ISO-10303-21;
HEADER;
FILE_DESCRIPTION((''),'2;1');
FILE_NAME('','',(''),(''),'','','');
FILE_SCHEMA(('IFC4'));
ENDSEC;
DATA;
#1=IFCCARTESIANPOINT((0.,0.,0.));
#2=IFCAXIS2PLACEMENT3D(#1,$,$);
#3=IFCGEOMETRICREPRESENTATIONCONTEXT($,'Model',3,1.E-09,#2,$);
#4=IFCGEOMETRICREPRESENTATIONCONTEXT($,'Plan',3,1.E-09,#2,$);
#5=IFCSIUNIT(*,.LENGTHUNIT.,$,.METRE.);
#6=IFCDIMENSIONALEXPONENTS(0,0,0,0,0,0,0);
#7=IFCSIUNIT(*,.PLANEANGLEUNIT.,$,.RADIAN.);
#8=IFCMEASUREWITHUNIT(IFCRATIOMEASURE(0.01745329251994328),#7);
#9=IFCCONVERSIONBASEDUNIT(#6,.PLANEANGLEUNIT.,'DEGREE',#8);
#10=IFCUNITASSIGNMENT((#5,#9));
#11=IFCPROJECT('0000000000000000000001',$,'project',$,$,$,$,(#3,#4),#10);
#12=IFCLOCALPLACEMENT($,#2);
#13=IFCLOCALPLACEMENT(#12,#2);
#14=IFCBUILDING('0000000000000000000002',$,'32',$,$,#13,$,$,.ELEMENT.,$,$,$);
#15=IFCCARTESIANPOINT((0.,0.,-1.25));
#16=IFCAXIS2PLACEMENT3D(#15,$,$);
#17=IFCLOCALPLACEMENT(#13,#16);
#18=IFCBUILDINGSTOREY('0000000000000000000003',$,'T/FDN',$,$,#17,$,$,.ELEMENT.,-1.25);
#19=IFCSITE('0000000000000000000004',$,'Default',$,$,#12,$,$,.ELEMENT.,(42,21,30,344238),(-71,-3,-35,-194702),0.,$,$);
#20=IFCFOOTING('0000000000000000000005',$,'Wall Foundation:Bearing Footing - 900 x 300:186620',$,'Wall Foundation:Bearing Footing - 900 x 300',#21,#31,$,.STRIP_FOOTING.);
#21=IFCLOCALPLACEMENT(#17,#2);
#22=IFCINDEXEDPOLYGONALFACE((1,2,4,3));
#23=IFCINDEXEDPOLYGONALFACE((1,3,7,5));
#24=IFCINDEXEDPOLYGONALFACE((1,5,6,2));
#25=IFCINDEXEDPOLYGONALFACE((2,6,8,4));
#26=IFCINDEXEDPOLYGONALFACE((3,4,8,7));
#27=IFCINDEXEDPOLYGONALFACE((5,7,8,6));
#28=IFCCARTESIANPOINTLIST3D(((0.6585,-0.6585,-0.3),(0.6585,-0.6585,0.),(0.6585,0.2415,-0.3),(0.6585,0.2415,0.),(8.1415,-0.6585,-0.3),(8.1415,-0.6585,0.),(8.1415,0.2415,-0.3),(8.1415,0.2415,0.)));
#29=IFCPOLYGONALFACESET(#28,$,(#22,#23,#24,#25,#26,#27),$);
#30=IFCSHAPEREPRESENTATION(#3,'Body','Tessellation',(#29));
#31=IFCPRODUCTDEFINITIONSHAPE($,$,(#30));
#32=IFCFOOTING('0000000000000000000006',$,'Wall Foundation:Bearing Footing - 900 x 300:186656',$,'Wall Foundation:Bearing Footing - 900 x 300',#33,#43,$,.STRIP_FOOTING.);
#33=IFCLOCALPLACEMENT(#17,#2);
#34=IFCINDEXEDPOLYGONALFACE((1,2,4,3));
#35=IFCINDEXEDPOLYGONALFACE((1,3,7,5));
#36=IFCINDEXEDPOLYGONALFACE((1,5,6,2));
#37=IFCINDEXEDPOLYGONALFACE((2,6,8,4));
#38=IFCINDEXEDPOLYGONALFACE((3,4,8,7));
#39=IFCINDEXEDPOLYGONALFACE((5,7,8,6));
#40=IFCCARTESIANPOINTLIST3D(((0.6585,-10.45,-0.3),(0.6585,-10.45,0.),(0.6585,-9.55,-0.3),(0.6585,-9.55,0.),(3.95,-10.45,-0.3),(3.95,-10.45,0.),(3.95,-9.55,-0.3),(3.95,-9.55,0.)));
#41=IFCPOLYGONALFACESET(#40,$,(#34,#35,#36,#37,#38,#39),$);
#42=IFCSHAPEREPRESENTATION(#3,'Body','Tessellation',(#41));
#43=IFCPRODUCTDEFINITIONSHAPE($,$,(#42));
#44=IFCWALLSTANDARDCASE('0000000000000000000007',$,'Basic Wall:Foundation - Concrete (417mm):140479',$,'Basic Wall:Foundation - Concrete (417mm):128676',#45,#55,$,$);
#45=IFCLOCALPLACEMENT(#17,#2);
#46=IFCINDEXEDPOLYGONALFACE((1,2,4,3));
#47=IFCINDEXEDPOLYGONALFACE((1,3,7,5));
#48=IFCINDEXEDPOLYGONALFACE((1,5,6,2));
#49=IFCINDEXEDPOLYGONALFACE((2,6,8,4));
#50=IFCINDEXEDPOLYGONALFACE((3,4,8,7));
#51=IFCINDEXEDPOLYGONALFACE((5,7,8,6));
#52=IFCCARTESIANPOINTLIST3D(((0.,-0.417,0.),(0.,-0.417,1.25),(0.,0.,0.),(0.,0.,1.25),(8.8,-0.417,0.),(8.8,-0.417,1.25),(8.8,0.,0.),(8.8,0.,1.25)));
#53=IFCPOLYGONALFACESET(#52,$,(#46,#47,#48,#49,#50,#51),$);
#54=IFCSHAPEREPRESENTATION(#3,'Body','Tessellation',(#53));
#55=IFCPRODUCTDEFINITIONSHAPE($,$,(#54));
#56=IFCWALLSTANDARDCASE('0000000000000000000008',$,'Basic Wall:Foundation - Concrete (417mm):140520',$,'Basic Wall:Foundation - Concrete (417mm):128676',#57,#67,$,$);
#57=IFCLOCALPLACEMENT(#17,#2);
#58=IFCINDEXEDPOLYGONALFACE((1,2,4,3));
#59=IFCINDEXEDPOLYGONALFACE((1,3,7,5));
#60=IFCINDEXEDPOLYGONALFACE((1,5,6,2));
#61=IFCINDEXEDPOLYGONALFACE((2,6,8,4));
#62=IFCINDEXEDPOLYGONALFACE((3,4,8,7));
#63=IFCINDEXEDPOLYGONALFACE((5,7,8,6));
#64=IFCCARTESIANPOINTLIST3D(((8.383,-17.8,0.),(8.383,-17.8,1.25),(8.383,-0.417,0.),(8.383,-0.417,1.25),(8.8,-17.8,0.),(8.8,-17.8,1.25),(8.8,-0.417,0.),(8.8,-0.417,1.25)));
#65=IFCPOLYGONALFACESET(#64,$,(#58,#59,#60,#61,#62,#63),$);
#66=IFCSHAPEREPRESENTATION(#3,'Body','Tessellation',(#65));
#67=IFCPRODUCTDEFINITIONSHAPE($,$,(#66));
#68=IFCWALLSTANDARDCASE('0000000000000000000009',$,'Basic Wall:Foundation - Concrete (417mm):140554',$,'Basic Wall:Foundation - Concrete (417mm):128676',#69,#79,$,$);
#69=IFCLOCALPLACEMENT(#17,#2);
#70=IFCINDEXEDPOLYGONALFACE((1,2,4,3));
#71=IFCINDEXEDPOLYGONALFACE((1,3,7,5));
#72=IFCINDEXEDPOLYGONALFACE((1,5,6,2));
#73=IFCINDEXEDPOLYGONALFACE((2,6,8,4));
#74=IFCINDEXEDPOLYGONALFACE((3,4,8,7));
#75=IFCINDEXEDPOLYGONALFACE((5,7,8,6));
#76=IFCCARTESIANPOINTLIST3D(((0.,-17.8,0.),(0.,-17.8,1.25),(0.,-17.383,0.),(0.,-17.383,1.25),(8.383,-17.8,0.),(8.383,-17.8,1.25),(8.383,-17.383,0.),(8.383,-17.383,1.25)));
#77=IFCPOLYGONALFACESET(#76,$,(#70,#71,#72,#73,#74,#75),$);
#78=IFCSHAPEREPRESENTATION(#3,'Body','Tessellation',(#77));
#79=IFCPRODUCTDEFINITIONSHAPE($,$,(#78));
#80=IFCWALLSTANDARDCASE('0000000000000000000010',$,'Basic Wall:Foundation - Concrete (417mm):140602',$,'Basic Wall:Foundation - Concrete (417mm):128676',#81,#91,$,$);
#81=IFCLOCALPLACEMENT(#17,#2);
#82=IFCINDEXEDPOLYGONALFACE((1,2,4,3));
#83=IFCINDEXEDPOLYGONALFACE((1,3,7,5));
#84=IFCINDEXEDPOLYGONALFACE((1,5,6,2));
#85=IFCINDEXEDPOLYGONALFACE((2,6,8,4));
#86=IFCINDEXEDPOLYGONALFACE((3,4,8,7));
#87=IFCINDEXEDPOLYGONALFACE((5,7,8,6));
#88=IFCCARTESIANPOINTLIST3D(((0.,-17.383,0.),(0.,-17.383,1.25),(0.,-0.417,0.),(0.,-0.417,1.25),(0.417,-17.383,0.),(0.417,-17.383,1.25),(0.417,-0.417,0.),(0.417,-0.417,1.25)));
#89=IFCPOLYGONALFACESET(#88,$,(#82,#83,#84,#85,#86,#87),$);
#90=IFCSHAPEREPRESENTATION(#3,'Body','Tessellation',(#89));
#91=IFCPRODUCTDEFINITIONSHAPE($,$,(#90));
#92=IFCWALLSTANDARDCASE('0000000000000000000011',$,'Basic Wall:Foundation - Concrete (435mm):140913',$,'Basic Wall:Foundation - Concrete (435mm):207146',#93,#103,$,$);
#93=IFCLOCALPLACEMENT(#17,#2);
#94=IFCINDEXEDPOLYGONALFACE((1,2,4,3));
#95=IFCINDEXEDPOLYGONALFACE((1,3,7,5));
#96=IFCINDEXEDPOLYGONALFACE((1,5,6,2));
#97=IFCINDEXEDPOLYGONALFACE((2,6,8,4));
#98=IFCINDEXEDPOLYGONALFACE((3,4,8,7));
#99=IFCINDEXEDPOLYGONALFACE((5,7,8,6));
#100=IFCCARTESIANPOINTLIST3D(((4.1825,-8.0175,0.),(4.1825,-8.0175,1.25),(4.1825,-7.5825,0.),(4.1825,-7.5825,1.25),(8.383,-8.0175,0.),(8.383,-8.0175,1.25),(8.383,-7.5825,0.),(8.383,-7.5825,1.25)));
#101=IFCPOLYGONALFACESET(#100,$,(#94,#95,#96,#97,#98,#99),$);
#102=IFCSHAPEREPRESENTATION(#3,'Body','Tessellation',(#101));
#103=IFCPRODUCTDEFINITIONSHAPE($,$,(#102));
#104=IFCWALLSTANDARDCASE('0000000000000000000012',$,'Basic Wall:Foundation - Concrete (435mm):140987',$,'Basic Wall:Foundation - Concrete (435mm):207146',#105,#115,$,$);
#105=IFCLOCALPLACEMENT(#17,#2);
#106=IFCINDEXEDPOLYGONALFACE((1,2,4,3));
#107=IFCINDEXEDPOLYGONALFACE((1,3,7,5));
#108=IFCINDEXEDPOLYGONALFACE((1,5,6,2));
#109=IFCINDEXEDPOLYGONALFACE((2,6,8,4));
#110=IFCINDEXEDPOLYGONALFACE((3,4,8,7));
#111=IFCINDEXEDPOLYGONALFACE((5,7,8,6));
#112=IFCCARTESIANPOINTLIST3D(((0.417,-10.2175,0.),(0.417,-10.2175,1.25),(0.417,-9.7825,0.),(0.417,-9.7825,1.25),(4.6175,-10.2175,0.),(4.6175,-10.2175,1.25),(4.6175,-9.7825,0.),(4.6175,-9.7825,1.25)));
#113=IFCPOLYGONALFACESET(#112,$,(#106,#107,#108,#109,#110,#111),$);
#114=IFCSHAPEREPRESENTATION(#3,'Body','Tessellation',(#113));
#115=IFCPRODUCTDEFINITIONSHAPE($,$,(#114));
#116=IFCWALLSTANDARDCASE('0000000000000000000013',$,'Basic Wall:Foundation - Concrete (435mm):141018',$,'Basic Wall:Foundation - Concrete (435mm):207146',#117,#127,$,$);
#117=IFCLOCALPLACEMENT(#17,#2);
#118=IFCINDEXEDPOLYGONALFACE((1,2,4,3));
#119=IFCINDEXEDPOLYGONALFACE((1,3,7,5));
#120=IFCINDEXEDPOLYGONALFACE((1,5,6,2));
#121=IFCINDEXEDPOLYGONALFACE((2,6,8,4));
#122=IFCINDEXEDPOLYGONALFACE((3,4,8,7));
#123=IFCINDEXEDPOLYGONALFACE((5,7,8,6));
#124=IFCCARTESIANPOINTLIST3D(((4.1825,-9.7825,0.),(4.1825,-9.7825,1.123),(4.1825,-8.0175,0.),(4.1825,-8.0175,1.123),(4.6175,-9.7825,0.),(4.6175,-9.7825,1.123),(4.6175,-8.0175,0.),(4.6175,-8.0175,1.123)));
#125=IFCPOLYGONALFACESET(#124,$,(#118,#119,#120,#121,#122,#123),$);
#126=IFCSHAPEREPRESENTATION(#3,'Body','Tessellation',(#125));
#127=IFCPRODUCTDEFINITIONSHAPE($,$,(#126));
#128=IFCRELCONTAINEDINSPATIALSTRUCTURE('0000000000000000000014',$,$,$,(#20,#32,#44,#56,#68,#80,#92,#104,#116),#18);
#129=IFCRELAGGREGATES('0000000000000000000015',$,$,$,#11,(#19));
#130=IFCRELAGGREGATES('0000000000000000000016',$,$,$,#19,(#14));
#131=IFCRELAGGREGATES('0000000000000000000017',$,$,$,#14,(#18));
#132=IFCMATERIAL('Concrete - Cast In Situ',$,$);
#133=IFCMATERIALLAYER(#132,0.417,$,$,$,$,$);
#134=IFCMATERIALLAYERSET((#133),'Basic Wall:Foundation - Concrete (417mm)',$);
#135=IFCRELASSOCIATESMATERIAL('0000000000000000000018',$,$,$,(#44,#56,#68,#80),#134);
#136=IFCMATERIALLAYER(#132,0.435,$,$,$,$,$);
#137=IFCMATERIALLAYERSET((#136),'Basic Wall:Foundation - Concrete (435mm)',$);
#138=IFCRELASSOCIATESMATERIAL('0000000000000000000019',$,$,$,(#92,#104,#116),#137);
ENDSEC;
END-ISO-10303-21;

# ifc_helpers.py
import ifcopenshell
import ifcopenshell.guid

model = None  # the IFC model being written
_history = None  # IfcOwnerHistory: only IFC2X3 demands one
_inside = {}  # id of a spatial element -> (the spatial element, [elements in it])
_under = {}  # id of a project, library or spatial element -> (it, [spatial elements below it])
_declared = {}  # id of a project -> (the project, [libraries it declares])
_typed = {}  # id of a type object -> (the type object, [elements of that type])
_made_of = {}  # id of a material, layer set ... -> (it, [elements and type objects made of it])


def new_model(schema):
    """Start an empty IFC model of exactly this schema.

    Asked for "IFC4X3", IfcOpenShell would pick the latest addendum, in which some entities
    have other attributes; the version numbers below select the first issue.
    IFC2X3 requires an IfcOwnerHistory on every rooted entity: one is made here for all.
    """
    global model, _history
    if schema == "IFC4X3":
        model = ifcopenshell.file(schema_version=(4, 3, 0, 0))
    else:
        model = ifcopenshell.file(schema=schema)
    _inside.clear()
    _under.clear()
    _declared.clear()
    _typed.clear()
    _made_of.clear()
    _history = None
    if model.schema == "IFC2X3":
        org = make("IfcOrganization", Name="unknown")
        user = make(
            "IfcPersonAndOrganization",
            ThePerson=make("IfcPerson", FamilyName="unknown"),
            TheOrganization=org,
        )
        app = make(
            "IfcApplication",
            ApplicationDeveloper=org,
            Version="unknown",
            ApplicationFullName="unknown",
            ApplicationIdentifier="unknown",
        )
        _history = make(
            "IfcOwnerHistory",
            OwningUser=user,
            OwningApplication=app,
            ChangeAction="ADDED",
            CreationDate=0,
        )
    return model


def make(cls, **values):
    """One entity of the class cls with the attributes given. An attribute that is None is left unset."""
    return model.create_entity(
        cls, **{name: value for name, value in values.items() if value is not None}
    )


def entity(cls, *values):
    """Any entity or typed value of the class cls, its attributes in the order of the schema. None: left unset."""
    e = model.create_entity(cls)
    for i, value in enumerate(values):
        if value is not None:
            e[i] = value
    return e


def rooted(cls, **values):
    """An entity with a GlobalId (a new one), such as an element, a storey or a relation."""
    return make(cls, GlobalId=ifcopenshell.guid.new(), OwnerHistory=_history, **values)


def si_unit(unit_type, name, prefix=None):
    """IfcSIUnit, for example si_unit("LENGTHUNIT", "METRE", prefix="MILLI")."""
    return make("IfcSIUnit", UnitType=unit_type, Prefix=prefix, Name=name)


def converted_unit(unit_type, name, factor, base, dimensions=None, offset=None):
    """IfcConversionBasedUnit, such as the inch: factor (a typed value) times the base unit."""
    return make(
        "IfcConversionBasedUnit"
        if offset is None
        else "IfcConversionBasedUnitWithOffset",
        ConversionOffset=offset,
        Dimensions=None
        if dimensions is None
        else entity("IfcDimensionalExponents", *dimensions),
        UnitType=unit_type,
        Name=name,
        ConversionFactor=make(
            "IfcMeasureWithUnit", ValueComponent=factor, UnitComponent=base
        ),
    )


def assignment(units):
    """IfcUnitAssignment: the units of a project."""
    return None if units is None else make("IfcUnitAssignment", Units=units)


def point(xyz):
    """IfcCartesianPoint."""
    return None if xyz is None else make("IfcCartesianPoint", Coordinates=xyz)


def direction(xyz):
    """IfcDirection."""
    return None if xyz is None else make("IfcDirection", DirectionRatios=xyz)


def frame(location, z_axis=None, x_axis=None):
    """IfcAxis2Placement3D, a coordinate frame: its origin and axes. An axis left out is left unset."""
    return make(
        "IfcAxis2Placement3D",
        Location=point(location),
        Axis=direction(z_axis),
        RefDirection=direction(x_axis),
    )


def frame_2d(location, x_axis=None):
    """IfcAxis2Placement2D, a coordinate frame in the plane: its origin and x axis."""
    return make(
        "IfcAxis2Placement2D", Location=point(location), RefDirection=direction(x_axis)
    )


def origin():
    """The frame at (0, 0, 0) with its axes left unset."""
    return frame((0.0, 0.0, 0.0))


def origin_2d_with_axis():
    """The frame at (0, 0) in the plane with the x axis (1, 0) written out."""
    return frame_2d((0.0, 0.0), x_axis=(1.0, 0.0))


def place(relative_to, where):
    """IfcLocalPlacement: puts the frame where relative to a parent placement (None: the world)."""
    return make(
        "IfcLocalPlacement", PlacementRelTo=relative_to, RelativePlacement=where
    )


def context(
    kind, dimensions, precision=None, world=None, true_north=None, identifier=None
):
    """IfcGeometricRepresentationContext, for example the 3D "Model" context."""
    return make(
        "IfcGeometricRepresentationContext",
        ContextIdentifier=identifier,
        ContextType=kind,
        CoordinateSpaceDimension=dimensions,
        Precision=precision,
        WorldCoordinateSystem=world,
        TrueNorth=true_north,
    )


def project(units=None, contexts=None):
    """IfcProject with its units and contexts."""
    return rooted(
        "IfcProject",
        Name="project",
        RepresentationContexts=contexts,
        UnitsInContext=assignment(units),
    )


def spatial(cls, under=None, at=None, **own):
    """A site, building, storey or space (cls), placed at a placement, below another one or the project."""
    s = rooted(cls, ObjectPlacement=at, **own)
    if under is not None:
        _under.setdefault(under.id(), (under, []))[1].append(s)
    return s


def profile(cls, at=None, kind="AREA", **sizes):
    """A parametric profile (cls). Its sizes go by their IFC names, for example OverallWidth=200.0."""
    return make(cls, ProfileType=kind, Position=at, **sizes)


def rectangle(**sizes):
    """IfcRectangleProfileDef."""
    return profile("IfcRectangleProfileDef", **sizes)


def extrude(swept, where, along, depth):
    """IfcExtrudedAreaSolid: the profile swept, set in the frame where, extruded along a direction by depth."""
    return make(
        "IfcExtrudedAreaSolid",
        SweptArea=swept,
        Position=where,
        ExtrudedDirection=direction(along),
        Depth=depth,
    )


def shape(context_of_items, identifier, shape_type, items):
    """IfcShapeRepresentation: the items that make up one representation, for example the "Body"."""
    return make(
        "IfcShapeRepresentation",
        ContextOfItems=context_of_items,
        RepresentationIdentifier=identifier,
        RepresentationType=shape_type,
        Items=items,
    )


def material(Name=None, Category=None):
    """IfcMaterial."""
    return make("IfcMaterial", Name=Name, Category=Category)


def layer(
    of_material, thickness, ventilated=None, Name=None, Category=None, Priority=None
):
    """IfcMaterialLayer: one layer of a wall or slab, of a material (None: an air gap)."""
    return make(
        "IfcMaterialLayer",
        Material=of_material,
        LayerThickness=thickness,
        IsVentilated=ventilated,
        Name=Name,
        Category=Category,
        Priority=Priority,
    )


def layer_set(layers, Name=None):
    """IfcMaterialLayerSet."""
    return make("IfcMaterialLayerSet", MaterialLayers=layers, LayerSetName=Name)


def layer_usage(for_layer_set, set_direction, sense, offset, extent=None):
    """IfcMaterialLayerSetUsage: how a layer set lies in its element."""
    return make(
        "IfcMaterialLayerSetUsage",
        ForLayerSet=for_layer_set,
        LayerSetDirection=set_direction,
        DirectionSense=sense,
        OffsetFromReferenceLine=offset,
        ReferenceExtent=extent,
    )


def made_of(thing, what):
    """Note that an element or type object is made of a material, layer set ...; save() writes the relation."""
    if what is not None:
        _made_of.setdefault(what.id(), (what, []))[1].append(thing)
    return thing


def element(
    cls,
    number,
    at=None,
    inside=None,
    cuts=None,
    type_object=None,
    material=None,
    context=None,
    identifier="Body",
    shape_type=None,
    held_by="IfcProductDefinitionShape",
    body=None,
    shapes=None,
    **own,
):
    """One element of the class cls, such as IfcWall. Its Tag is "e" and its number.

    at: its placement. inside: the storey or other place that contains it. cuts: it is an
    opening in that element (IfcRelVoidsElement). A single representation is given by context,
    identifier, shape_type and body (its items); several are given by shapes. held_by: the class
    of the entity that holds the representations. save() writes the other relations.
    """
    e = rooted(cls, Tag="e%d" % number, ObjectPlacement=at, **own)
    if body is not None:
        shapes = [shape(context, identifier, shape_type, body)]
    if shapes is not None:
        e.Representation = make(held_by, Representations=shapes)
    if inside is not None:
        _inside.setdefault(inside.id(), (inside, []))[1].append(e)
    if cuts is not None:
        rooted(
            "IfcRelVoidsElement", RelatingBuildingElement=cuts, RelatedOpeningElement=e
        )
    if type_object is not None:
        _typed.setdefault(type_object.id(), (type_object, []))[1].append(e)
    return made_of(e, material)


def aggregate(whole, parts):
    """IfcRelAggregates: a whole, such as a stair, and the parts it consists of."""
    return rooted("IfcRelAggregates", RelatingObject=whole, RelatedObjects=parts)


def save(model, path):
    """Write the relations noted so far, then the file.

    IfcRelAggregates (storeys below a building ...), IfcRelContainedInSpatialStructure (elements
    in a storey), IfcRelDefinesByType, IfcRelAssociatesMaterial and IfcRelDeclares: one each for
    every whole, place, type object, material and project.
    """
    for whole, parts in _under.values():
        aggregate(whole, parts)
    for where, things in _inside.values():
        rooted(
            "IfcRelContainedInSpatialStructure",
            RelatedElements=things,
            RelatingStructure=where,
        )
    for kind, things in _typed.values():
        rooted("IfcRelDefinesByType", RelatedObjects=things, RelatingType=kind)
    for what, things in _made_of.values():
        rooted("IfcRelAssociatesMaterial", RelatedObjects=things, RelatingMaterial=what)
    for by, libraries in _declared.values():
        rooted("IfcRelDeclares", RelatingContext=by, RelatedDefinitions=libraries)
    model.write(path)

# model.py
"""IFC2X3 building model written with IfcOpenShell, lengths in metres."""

from ifc_helpers import new_model, entity, si_unit, converted_unit, frame, frame_2d, origin, origin_2d_with_axis, place, context, project, spatial, rectangle, extrude, material, layer, layer_set, layer_usage, element, save


model = new_model("IFC2X3")

# Units and contexts
model_context = context("Model", 3, precision=1e-09, world=origin())
plan_context = context("Plan", 3, precision=1e-09, world=origin())
ifc_project = project(units=[si_unit("LENGTHUNIT", "METRE"), converted_unit("PLANEANGLEUNIT", "DEGREE", entity("IfcRatioMeasure", 0.01745329251994328), si_unit("PLANEANGLEUNIT", "RADIAN"), dimensions=[0, 0, 0, 0, 0, 0, 0])], contexts=[model_context, plan_context])

# Site, building, storey
site_placement = place(None, origin())
site = spatial("IfcSite", under=ifc_project, at=site_placement, Name="Default", CompositionType="ELEMENT", RefLatitude=(42, 21, 30, 344238), RefLongitude=(-71, -3, -35, -194702), RefElevation=0.0)
building_placement = place(site_placement, origin())
building = spatial("IfcBuilding", under=site, at=building_placement, Name="32", CompositionType="ELEMENT")
storey_placement = place(building_placement, frame((0.0, 0.0, -1.25)))
storey = spatial("IfcBuildingStorey", under=building, at=storey_placement, Name="T/FDN", CompositionType="ELEMENT", Elevation=-1.25)

# Footings
footing_1_placement = place(storey_placement, origin())
element("IfcFooting", 1, at=footing_1_placement, inside=storey, Name="Wall Foundation:Bearing Footing - 900 x 300:186620", ObjectType="Wall Foundation:Bearing Footing - 900 x 300", PredefinedType="STRIP_FOOTING", context=model_context, shape_type="SweptSolid", body=[
    extrude(rectangle(XDim=7.483, YDim=0.9, at=origin_2d_with_axis()), frame((4.4, -0.2085, -0.3), z_axis=(0.0, 0.0, 1.0), x_axis=(-1.0, 0.0, 0.0)), (0.0, 0.0, 1.0), 0.3),
])
footing_2_placement = place(storey_placement, origin())
element("IfcFooting", 2, at=footing_2_placement, inside=storey, Name="Wall Foundation:Bearing Footing - 900 x 300:186656", ObjectType="Wall Foundation:Bearing Footing - 900 x 300", PredefinedType="STRIP_FOOTING", context=model_context, shape_type="SweptSolid", body=[
    extrude(rectangle(XDim=3.2915, YDim=0.9, at=origin_2d_with_axis()), frame((2.3042, -10.0, -0.3)), (0.0, 0.0, 1.0), 0.3),
])

# Walls
ifc_material = material(Name="Concrete - Cast In Situ")
ifc_layer_1 = layer(ifc_material, 0.417)
ifc_layer_set_1 = layer_set([ifc_layer_1], Name="Basic Wall:Foundation - Concrete (417mm)")
ifc_layer_usage_1 = layer_usage(ifc_layer_set_1, "AXIS2", "NEGATIVE", 0.2085)
wall_1_placement = place(storey_placement, frame((0.0, -0.2085, 0.0)))
element("IfcWallStandardCase", 3, at=wall_1_placement, inside=storey, material=ifc_layer_usage_1, Name="Basic Wall:Foundation - Concrete (417mm):140479", ObjectType="Basic Wall:Foundation - Concrete (417mm):128676", context=model_context, shape_type="SweptSolid", body=[
    extrude(rectangle(XDim=8.8, YDim=0.417, at=frame_2d((4.4, 0.0), x_axis=(-1.0, 0.0))), origin(), (0.0, 0.0, 1.0), 1.25),
])
ifc_layer_usage_2 = layer_usage(ifc_layer_set_1, "AXIS2", "NEGATIVE", 0.2085)
wall_2_placement = place(storey_placement, frame((8.5915, -0.417, 0.0), z_axis=(0.0, 0.0, 1.0), x_axis=(0.0, -1.0, 0.0)))
element("IfcWallStandardCase", 4, at=wall_2_placement, inside=storey, material=ifc_layer_usage_2, Name="Basic Wall:Foundation - Concrete (417mm):140520", ObjectType="Basic Wall:Foundation - Concrete (417mm):128676", context=model_context, shape_type="SweptSolid", body=[
    extrude(rectangle(XDim=17.383, YDim=0.417, at=frame_2d((8.6915, 0.0), x_axis=(-1.0, 0.0))), origin(), (0.0, 0.0, 1.0), 1.25),
])
ifc_layer_usage_3 = layer_usage(ifc_layer_set_1, "AXIS2", "NEGATIVE", 0.2085)
wall_3_placement = place(storey_placement, frame((8.383, -17.5915, 0.0), z_axis=(0.0, 0.0, 1.0), x_axis=(-1.0, 0.0, 0.0)))
element("IfcWallStandardCase", 5, at=wall_3_placement, inside=storey, material=ifc_layer_usage_3, Name="Basic Wall:Foundation - Concrete (417mm):140554", ObjectType="Basic Wall:Foundation - Concrete (417mm):128676", context=model_context, shape_type="SweptSolid", body=[
    extrude(rectangle(XDim=8.383, YDim=0.417, at=frame_2d((4.1915, 0.0), x_axis=(-1.0, 0.0))), origin(), (0.0, 0.0, 1.0), 1.25),
])
ifc_layer_usage_4 = layer_usage(ifc_layer_set_1, "AXIS2", "NEGATIVE", 0.2085)
wall_4_placement = place(storey_placement, frame((0.2085, -17.383, 0.0), z_axis=(0.0, 0.0, 1.0), x_axis=(0.0, 1.0, 0.0)))
element("IfcWallStandardCase", 6, at=wall_4_placement, inside=storey, material=ifc_layer_usage_4, Name="Basic Wall:Foundation - Concrete (417mm):140602", ObjectType="Basic Wall:Foundation - Concrete (417mm):128676", context=model_context, shape_type="SweptSolid", body=[
    extrude(rectangle(XDim=16.966, YDim=0.417, at=frame_2d((8.483, 0.0), x_axis=(-1.0, 0.0))), origin(), (0.0, 0.0, 1.0), 1.25),
])
ifc_layer_2 = layer(ifc_material, 0.435)
ifc_layer_set_2 = layer_set([ifc_layer_2], Name="Basic Wall:Foundation - Concrete (435mm)")
ifc_layer_usage_5 = layer_usage(ifc_layer_set_2, "AXIS2", "NEGATIVE", 0.2175)
wall_5_placement = place(storey_placement, frame((8.383, -7.8, 0.0), z_axis=(0.0, 0.0, 1.0), x_axis=(-1.0, 0.0, 0.0)))
element("IfcWallStandardCase", 7, at=wall_5_placement, inside=storey, material=ifc_layer_usage_5, Name="Basic Wall:Foundation - Concrete (435mm):140913", ObjectType="Basic Wall:Foundation - Concrete (435mm):207146", context=model_context, shape_type="SweptSolid", body=[
    extrude(rectangle(XDim=4.2005, YDim=0.435, at=frame_2d((2.1002, 0.0), x_axis=(-1.0, 0.0))), origin(), (0.0, 0.0, 1.0), 1.25),
])
ifc_layer_usage_6 = layer_usage(ifc_layer_set_2, "AXIS2", "NEGATIVE", 0.2175)
wall_6_placement = place(storey_placement, frame((0.417, -10.0, 0.0)))
element("IfcWallStandardCase", 8, at=wall_6_placement, inside=storey, material=ifc_layer_usage_6, Name="Basic Wall:Foundation - Concrete (435mm):140987", ObjectType="Basic Wall:Foundation - Concrete (435mm):207146", context=model_context, shape_type="SweptSolid", body=[
    extrude(rectangle(XDim=4.2005, YDim=0.435, at=frame_2d((2.1002, 0.0), x_axis=(-1.0, 0.0))), origin(), (0.0, 0.0, 1.0), 1.25),
])
ifc_layer_usage_7 = layer_usage(ifc_layer_set_2, "AXIS2", "NEGATIVE", 0.2175)
wall_7_placement = place(storey_placement, frame((4.4, -9.7825, 0.0), z_axis=(0.0, 0.0, 1.0), x_axis=(0.0, 1.0, 0.0)))
element("IfcWallStandardCase", 9, at=wall_7_placement, inside=storey, material=ifc_layer_usage_7, Name="Basic Wall:Foundation - Concrete (435mm):141018", ObjectType="Basic Wall:Foundation - Concrete (435mm):207146", context=model_context, shape_type="SweptSolid", body=[
    extrude(rectangle(XDim=1.765, YDim=0.435, at=frame_2d((0.8825, 0.0), x_axis=(-1.0, 0.0))), origin(), (0.0, 0.0, 1.0), 1.123),
])

save(model, "model.ifc")
